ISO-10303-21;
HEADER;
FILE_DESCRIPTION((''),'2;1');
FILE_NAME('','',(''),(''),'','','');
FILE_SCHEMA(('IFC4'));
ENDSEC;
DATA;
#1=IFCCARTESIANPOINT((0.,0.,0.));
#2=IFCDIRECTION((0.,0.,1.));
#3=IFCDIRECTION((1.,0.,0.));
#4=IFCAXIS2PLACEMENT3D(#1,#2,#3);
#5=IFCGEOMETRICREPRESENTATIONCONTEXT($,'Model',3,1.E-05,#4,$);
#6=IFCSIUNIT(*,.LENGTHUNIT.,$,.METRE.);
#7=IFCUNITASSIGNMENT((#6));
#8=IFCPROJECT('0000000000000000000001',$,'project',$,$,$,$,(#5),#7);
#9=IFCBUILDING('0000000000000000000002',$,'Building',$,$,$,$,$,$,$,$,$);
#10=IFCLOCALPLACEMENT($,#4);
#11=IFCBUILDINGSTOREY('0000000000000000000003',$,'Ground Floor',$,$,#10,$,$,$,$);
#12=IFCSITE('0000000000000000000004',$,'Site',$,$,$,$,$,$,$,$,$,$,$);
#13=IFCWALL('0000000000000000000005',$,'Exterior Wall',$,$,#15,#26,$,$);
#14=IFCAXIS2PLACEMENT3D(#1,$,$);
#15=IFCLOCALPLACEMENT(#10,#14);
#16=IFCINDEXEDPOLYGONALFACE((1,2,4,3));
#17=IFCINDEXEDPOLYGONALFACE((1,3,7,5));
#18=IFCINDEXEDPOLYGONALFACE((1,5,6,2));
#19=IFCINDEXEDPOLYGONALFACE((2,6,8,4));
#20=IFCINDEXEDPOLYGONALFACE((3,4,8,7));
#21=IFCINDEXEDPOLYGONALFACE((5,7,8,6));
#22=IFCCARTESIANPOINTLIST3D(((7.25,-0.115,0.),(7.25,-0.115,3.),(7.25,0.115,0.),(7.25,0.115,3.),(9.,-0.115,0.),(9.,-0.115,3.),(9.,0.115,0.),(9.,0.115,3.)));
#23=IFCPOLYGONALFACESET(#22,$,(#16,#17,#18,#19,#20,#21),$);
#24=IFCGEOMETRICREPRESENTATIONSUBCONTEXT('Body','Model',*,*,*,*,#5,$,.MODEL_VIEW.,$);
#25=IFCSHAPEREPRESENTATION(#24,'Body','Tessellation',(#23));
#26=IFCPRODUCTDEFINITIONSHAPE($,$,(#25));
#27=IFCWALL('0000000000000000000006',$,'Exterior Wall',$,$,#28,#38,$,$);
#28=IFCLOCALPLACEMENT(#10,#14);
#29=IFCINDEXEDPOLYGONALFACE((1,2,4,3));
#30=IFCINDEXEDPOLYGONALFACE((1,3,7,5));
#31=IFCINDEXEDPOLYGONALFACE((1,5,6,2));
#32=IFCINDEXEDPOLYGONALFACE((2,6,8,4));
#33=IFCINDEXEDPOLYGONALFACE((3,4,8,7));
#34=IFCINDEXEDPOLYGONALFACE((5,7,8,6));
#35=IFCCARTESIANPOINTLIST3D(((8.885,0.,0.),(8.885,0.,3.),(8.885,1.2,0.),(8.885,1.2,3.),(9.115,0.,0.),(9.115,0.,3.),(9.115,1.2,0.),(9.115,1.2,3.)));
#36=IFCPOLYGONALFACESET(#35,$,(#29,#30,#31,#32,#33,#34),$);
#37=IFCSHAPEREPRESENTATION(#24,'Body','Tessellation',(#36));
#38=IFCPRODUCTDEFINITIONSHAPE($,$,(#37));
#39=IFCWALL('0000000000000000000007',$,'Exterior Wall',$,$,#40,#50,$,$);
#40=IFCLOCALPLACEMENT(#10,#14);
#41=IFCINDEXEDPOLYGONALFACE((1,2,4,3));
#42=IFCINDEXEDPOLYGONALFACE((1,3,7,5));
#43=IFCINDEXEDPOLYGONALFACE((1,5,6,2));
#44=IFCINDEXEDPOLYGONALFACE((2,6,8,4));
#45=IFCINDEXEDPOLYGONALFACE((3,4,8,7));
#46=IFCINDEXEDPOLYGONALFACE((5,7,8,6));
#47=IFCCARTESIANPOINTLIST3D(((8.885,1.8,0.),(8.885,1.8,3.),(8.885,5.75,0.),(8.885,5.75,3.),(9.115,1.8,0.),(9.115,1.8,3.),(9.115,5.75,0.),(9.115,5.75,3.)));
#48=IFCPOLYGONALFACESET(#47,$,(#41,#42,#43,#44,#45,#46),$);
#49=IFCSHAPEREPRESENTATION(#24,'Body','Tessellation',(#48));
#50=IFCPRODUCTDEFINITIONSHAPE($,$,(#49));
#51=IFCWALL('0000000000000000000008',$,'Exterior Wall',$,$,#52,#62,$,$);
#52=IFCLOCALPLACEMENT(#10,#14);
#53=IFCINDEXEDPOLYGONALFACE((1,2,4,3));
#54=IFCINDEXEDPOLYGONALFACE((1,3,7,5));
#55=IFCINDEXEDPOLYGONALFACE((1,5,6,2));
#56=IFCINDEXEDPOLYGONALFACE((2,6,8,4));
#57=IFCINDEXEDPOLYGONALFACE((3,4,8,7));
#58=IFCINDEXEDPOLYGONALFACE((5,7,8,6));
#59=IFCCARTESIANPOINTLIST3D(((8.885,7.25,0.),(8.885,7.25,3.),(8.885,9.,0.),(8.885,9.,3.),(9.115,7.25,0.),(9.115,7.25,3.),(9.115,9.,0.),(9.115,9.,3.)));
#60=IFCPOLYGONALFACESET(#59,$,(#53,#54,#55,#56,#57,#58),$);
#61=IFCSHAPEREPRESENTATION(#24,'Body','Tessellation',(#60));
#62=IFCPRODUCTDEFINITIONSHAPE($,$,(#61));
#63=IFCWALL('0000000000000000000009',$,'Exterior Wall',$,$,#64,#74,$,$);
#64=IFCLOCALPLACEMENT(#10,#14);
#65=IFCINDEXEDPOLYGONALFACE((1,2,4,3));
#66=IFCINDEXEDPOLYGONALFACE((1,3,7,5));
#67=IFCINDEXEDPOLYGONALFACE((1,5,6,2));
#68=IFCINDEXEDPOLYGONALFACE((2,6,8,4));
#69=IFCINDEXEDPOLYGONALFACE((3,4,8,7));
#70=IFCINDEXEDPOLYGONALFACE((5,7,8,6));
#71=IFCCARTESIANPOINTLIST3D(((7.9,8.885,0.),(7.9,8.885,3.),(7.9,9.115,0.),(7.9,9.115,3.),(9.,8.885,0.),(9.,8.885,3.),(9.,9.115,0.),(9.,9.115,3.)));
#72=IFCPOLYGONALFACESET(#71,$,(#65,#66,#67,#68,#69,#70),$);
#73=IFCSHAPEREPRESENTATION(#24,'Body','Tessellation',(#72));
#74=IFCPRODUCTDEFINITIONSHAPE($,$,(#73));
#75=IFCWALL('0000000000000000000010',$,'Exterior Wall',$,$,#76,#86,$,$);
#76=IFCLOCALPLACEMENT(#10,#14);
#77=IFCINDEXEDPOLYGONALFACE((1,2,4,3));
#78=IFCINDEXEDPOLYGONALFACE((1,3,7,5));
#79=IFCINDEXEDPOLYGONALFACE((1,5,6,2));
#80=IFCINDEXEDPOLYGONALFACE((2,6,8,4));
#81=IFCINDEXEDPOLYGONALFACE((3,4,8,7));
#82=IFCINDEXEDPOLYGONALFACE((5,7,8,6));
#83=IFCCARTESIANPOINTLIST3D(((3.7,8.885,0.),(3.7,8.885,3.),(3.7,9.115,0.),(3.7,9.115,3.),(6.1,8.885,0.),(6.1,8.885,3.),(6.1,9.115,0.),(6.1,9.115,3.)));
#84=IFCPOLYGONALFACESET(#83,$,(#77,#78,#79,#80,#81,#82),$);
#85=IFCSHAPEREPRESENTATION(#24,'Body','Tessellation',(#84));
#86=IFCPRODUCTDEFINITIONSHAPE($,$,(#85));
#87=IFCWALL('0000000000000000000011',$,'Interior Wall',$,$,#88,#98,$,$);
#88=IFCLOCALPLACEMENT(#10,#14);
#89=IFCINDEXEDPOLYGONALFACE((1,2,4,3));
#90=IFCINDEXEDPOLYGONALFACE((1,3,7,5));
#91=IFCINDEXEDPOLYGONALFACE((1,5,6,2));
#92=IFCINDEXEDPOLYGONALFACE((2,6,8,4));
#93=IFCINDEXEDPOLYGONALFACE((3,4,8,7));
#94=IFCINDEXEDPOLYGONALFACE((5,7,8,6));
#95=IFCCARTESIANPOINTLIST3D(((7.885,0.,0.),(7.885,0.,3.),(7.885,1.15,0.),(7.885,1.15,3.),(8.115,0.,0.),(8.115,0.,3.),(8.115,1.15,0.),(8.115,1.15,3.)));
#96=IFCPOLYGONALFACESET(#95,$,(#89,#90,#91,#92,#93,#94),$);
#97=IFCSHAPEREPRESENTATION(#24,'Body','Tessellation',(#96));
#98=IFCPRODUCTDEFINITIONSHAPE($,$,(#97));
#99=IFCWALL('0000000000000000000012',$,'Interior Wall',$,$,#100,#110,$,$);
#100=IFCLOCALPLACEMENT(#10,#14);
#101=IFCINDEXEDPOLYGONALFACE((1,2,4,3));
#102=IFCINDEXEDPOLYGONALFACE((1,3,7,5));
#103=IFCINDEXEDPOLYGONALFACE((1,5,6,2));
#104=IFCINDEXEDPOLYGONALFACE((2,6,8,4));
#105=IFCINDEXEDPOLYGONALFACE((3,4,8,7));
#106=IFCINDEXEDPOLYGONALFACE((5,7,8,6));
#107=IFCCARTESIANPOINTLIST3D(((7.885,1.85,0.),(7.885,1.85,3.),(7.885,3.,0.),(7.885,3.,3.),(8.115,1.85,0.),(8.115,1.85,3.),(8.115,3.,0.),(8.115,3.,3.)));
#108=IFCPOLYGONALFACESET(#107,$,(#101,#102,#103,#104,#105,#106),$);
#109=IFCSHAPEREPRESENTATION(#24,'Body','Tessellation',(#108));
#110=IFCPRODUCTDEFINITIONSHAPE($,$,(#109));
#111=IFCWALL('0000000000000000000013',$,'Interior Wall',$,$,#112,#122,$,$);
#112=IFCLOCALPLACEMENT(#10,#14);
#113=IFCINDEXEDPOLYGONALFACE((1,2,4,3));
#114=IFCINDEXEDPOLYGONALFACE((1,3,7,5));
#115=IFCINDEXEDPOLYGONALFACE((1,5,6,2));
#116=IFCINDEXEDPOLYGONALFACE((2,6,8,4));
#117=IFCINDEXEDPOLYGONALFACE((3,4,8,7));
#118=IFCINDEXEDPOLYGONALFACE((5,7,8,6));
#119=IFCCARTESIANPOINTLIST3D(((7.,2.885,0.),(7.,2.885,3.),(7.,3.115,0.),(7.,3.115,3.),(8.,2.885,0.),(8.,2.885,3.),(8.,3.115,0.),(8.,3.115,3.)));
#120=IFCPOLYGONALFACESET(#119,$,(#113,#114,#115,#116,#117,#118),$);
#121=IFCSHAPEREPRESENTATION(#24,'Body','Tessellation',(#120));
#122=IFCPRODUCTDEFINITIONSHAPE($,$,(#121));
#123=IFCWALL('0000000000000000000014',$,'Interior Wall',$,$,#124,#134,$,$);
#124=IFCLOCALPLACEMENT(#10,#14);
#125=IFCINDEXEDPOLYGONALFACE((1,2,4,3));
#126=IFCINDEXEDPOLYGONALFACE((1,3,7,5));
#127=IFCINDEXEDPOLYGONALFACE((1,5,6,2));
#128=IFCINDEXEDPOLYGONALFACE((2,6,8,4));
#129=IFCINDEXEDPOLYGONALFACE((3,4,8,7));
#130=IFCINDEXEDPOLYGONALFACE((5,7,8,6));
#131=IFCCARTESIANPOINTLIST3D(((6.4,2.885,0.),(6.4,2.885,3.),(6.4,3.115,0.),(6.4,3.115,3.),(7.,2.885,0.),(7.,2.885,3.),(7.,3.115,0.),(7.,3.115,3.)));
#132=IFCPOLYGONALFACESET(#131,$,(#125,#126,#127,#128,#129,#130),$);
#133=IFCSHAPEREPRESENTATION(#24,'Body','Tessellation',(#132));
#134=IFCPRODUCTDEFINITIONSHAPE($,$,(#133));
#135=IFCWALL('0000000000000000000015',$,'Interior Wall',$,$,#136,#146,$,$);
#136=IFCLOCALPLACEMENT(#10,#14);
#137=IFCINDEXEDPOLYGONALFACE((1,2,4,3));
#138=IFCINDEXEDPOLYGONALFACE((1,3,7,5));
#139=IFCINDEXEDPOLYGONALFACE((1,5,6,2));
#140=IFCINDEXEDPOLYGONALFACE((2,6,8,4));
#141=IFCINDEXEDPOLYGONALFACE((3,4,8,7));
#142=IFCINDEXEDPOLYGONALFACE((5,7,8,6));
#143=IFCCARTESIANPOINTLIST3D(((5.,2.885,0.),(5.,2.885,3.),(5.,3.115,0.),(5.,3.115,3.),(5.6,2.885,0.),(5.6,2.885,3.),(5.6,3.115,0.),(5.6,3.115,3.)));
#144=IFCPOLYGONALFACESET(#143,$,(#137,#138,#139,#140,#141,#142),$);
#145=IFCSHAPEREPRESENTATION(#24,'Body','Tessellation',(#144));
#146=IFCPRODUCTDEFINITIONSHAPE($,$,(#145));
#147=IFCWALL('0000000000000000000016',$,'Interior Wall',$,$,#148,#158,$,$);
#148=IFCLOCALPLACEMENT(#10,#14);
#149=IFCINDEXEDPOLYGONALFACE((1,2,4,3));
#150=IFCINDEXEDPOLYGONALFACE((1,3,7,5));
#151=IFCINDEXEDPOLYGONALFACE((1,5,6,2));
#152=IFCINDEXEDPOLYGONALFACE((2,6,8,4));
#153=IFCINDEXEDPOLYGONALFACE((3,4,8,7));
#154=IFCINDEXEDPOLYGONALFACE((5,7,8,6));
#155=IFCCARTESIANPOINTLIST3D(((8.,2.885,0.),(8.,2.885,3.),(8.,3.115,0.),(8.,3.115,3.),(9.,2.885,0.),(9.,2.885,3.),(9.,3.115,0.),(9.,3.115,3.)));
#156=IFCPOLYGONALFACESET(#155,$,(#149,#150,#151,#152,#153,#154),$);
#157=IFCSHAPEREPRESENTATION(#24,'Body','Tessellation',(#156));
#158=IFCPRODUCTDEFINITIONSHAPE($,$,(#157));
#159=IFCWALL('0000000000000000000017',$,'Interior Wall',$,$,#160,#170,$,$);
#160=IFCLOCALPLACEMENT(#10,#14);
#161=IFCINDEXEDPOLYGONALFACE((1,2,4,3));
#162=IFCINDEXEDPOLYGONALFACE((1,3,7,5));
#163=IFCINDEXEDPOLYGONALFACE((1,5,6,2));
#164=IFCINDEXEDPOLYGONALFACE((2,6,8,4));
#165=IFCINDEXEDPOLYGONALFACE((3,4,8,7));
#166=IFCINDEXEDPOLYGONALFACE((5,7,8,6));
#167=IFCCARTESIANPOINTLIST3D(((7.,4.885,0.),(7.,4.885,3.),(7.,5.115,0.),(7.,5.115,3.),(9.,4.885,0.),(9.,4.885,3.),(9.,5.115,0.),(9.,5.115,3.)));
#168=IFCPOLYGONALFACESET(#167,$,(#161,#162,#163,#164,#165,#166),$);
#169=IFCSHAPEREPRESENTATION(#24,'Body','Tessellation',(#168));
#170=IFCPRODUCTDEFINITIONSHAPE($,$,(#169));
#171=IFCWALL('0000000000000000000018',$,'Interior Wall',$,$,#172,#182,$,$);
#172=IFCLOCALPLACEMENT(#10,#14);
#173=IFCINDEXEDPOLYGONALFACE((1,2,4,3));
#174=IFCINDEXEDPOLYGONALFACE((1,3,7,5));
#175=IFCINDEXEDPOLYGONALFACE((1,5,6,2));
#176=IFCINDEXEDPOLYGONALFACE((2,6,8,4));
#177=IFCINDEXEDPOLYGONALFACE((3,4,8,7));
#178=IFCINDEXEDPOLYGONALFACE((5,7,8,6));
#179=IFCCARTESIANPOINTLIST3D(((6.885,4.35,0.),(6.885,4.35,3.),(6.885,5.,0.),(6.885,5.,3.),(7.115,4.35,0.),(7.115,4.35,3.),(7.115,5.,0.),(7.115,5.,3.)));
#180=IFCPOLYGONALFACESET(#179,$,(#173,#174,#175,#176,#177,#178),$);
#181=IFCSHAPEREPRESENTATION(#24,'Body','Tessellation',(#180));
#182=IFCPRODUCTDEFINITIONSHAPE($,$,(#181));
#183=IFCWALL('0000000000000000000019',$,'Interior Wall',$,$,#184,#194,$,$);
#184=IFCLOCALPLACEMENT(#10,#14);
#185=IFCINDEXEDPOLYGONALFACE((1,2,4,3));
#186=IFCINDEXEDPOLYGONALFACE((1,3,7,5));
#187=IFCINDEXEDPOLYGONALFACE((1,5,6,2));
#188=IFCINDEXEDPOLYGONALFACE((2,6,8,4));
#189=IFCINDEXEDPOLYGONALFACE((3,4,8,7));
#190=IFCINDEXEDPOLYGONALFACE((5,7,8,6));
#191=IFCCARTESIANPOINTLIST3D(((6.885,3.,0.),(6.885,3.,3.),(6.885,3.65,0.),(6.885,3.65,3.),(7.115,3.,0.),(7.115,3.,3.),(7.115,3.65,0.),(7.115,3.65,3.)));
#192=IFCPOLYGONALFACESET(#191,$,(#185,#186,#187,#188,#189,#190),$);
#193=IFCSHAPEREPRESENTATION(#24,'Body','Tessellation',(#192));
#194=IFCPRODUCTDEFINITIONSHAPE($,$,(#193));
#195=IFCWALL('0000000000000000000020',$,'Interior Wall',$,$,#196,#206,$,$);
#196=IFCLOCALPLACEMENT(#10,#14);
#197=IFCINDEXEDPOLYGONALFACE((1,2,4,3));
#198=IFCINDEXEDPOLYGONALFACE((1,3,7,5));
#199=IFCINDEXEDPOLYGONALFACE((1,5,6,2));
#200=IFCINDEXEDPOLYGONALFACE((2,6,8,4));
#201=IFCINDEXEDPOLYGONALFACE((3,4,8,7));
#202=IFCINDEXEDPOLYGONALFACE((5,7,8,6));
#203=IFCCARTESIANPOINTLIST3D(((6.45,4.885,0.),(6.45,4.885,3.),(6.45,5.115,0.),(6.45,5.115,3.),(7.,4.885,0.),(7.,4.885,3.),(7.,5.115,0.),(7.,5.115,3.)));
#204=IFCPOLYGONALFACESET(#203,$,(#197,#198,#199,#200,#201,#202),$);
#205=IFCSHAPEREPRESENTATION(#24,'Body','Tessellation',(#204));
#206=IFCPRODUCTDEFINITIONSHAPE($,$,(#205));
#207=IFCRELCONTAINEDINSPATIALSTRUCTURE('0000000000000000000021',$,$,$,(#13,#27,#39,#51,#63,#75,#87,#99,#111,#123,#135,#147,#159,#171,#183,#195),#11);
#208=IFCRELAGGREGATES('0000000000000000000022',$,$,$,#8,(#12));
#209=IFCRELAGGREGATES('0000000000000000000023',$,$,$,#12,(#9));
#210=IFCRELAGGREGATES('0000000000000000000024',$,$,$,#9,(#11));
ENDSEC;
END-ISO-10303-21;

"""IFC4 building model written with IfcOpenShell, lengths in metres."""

from ifc_helpers import new_model, si_unit, frame, origin_with_axes, place, context, subcontext, project, spatial, indexed_curve, outline, extrude, element, save


model = new_model("IFC4")

# Units and contexts
model_context = context("Model", 3, precision=1e-05, world=origin_with_axes())
body_context = subcontext(model_context, "Body", "Model", "MODEL_VIEW")
ifc_project = project(units=[si_unit("LENGTHUNIT", "METRE")], contexts=[model_context])

# Site, building, storey
site = spatial("IfcSite", under=ifc_project, Name="Site")
building = spatial("IfcBuilding", under=site, Name="Building")
storey_placement = place(None, origin_with_axes())
storey = spatial("IfcBuildingStorey", under=building, at=storey_placement, Name="Ground Floor")

# Walls
wall_1_placement = place(storey_placement, frame((7.25, 0.0, 0.0), z_axis=(0.0, 0.0, 1.0), x_axis=(1.0, 0.0, 0.0)))
element("IfcWall", 1, at=wall_1_placement, inside=storey, Name="Exterior Wall", context=body_context, shape_type="SweptSolid", body=[
    extrude(outline(indexed_curve([(0.0, 0.0), (0.0, 0.23), (1.75, 0.23), (1.75, 0.0), (0.0, 0.0)], self_intersect=False)), frame((0.0, -0.115, 0.0), z_axis=(0.0, 0.0, 1.0), x_axis=(1.0, 0.0, 0.0)), (0.0, 0.0, 1.0), 3.0),
])
wall_2_placement = place(storey_placement, frame((9.0, 0.0, 0.0), z_axis=(0.0, 0.0, 1.0), x_axis=(0.0, 1.0, 0.0)))
element("IfcWall", 2, at=wall_2_placement, inside=storey, Name="Exterior Wall", context=body_context, shape_type="SweptSolid", body=[
    extrude(outline(indexed_curve([(0.0, 0.0), (0.0, 0.23), (1.2, 0.23), (1.2, 0.0), (0.0, 0.0)], self_intersect=False)), frame((0.0, -0.115, 0.0), z_axis=(0.0, 0.0, 1.0), x_axis=(1.0, 0.0, 0.0)), (0.0, 0.0, 1.0), 3.0),
])
wall_3_placement = place(storey_placement, frame((9.0, 1.8, 0.0), z_axis=(0.0, 0.0, 1.0), x_axis=(0.0, 1.0, 0.0)))
element("IfcWall", 3, at=wall_3_placement, inside=storey, Name="Exterior Wall", context=body_context, shape_type="SweptSolid", body=[
    extrude(outline(indexed_curve([(0.0, 0.0), (0.0, 0.23), (3.95, 0.23), (3.95, 0.0), (0.0, 0.0)], self_intersect=False)), frame((0.0, -0.115, 0.0), z_axis=(0.0, 0.0, 1.0), x_axis=(1.0, 0.0, 0.0)), (0.0, 0.0, 1.0), 3.0),
])
wall_4_placement = place(storey_placement, frame((9.0, 7.25, 0.0), z_axis=(0.0, 0.0, 1.0), x_axis=(0.0, 1.0, 0.0)))
element("IfcWall", 4, at=wall_4_placement, inside=storey, Name="Exterior Wall", context=body_context, shape_type="SweptSolid", body=[
    extrude(outline(indexed_curve([(0.0, 0.0), (0.0, 0.23), (1.75, 0.23), (1.75, 0.0), (0.0, 0.0)], self_intersect=False)), frame((0.0, -0.115, 0.0), z_axis=(0.0, 0.0, 1.0), x_axis=(1.0, 0.0, 0.0)), (0.0, 0.0, 1.0), 3.0),
])
wall_5_placement = place(storey_placement, frame((9.0, 9.0, 0.0), z_axis=(0.0, 0.0, 1.0), x_axis=(-1.0, 0.0, 0.0)))
element("IfcWall", 5, at=wall_5_placement, inside=storey, Name="Exterior Wall", context=body_context, shape_type="SweptSolid", body=[
    extrude(outline(indexed_curve([(0.0, 0.0), (0.0, 0.23), (1.1, 0.23), (1.1, 0.0), (0.0, 0.0)], self_intersect=False)), frame((0.0, -0.115, 0.0), z_axis=(0.0, 0.0, 1.0), x_axis=(1.0, 0.0, 0.0)), (0.0, 0.0, 1.0), 3.0),
])
wall_6_placement = place(storey_placement, frame((6.1, 9.0, 0.0), z_axis=(0.0, 0.0, 1.0), x_axis=(-1.0, 0.0, 0.0)))
element("IfcWall", 6, at=wall_6_placement, inside=storey, Name="Exterior Wall", context=body_context, shape_type="SweptSolid", body=[
    extrude(outline(indexed_curve([(0.0, 0.0), (0.0, 0.23), (2.4, 0.23), (2.4, 0.0), (0.0, 0.0)], self_intersect=False)), frame((0.0, -0.115, 0.0), z_axis=(0.0, 0.0, 1.0), x_axis=(1.0, 0.0, 0.0)), (0.0, 0.0, 1.0), 3.0),
])
for number, where, z_axis, x_axis, name in (
    (7, (8.0, 0.0, 0.0), (0.0, 0.0, 1.0), (0.0, 1.0, 0.0), "Interior Wall"),
    (8, (8.0, 1.85, 0.0), (0.0, 0.0, 1.0), (0.0, 1.0, 0.0), "Interior Wall"),
):
    element("IfcWall", number, at=place(storey_placement, frame(where, z_axis=z_axis, x_axis=x_axis)), inside=storey, Name=name, context=body_context, shape_type="SweptSolid", body=[
        extrude(outline(indexed_curve([(0.0, 0.0), (0.0, 0.23), (1.15, 0.23), (1.15, 0.0), (0.0, 0.0)], self_intersect=False)), frame((0.0, -0.115, 0.0), z_axis=(0.0, 0.0, 1.0), x_axis=(1.0, 0.0, 0.0)), (0.0, 0.0, 1.0), 3.0),
    ])
wall_7_placement = place(storey_placement, frame((8.0, 3.0, 0.0), z_axis=(0.0, 0.0, 1.0), x_axis=(-1.0, 0.0, 0.0)))
element("IfcWall", 9, at=wall_7_placement, inside=storey, Name="Interior Wall", context=body_context, shape_type="SweptSolid", body=[
    extrude(outline(indexed_curve([(0.0, 0.0), (0.0, 0.23), (1.0, 0.23), (1.0, 0.0), (0.0, 0.0)], self_intersect=False)), frame((0.0, -0.115, 0.0), z_axis=(0.0, 0.0, 1.0), x_axis=(1.0, 0.0, 0.0)), (0.0, 0.0, 1.0), 3.0),
])
for number, where, z_axis, x_axis, name in (
    (10, (7.0, 3.0, 0.0), (0.0, 0.0, 1.0), (-1.0, 0.0, 0.0), "Interior Wall"),
    (11, (5.6, 3.0, 0.0), (0.0, 0.0, 1.0), (-1.0, 0.0, 0.0), "Interior Wall"),
):
    element("IfcWall", number, at=place(storey_placement, frame(where, z_axis=z_axis, x_axis=x_axis)), inside=storey, Name=name, context=body_context, shape_type="SweptSolid", body=[
        extrude(outline(indexed_curve([(0.0, 0.0), (0.0, 0.23), (0.6, 0.23), (0.6, 0.0), (0.0, 0.0)], self_intersect=False)), frame((0.0, -0.115, 0.0), z_axis=(0.0, 0.0, 1.0), x_axis=(1.0, 0.0, 0.0)), (0.0, 0.0, 1.0), 3.0),
    ])
wall_8_placement = place(storey_placement, frame((9.0, 3.0, 0.0), z_axis=(0.0, 0.0, 1.0), x_axis=(-1.0, 0.0, 0.0)))
element("IfcWall", 12, at=wall_8_placement, inside=storey, Name="Interior Wall", context=body_context, shape_type="SweptSolid", body=[
    extrude(outline(indexed_curve([(0.0, 0.0), (0.0, 0.23), (1.0, 0.23), (1.0, 0.0), (0.0, 0.0)], self_intersect=False)), frame((0.0, -0.115, 0.0), z_axis=(0.0, 0.0, 1.0), x_axis=(1.0, 0.0, 0.0)), (0.0, 0.0, 1.0), 3.0),
])
wall_9_placement = place(storey_placement, frame((9.0, 5.0, 0.0), z_axis=(0.0, 0.0, 1.0), x_axis=(-1.0, 0.0, 0.0)))
element("IfcWall", 13, at=wall_9_placement, inside=storey, Name="Interior Wall", context=body_context, shape_type="SweptSolid", body=[
    extrude(outline(indexed_curve([(0.0, 0.0), (0.0, 0.23), (2.0, 0.23), (2.0, 0.0), (0.0, 0.0)], self_intersect=False)), frame((0.0, -0.115, 0.0), z_axis=(0.0, 0.0, 1.0), x_axis=(1.0, 0.0, 0.0)), (0.0, 0.0, 1.0), 3.0),
])
wall_10_placement = place(storey_placement, frame((7.0, 5.0, 0.0), z_axis=(0.0, 0.0, 1.0), x_axis=(0.0, -1.0, 0.0)))
element("IfcWall", 14, at=wall_10_placement, inside=storey, Name="Interior Wall", context=body_context, shape_type="SweptSolid", body=[
    extrude(outline(indexed_curve([(0.0, 0.0), (0.0, 0.23), (0.65, 0.23), (0.65, 0.0), (0.0, 0.0)], self_intersect=False)), frame((0.0, -0.115, 0.0), z_axis=(0.0, 0.0, 1.0), x_axis=(1.0, 0.0, 0.0)), (0.0, 0.0, 1.0), 3.0),
])
wall_11_placement = place(storey_placement, frame((7.0, 3.65, 0.0), z_axis=(0.0, 0.0, 1.0), x_axis=(0.0, -1.0, 0.0)))
element("IfcWall", 15, at=wall_11_placement, inside=storey, Name="Interior Wall", context=body_context, shape_type="SweptSolid", body=[
    extrude(outline(indexed_curve([(0.0, 0.0), (0.0, 0.23), (0.65, 0.23), (0.65, 0.0), (0.0, 0.0)], self_intersect=False)), frame((0.0, -0.115, 0.0), z_axis=(0.0, 0.0, 1.0), x_axis=(1.0, 0.0, 0.0)), (0.0, 0.0, 1.0), 3.0),
])
for number, where, z_axis, x_axis, name in (
    (16, (7.0, 5.0, 0.0), (0.0, 0.0, 1.0), (-1.0, 0.0, 0.0), "Interior Wall"),
):
    element("IfcWall", number, at=place(storey_placement, frame(where, z_axis=z_axis, x_axis=x_axis)), inside=storey, Name=name, context=body_context, shape_type="SweptSolid", body=[
        extrude(outline(indexed_curve([(0.0, 0.0), (0.0, 0.23), (0.55, 0.23), (0.55, 0.0), (0.0, 0.0)], self_intersect=False)), frame((0.0, -0.115, 0.0), z_axis=(0.0, 0.0, 1.0), x_axis=(1.0, 0.0, 0.0)), (0.0, 0.0, 1.0), 3.0),
    ])

save(model, "model.ifc")
